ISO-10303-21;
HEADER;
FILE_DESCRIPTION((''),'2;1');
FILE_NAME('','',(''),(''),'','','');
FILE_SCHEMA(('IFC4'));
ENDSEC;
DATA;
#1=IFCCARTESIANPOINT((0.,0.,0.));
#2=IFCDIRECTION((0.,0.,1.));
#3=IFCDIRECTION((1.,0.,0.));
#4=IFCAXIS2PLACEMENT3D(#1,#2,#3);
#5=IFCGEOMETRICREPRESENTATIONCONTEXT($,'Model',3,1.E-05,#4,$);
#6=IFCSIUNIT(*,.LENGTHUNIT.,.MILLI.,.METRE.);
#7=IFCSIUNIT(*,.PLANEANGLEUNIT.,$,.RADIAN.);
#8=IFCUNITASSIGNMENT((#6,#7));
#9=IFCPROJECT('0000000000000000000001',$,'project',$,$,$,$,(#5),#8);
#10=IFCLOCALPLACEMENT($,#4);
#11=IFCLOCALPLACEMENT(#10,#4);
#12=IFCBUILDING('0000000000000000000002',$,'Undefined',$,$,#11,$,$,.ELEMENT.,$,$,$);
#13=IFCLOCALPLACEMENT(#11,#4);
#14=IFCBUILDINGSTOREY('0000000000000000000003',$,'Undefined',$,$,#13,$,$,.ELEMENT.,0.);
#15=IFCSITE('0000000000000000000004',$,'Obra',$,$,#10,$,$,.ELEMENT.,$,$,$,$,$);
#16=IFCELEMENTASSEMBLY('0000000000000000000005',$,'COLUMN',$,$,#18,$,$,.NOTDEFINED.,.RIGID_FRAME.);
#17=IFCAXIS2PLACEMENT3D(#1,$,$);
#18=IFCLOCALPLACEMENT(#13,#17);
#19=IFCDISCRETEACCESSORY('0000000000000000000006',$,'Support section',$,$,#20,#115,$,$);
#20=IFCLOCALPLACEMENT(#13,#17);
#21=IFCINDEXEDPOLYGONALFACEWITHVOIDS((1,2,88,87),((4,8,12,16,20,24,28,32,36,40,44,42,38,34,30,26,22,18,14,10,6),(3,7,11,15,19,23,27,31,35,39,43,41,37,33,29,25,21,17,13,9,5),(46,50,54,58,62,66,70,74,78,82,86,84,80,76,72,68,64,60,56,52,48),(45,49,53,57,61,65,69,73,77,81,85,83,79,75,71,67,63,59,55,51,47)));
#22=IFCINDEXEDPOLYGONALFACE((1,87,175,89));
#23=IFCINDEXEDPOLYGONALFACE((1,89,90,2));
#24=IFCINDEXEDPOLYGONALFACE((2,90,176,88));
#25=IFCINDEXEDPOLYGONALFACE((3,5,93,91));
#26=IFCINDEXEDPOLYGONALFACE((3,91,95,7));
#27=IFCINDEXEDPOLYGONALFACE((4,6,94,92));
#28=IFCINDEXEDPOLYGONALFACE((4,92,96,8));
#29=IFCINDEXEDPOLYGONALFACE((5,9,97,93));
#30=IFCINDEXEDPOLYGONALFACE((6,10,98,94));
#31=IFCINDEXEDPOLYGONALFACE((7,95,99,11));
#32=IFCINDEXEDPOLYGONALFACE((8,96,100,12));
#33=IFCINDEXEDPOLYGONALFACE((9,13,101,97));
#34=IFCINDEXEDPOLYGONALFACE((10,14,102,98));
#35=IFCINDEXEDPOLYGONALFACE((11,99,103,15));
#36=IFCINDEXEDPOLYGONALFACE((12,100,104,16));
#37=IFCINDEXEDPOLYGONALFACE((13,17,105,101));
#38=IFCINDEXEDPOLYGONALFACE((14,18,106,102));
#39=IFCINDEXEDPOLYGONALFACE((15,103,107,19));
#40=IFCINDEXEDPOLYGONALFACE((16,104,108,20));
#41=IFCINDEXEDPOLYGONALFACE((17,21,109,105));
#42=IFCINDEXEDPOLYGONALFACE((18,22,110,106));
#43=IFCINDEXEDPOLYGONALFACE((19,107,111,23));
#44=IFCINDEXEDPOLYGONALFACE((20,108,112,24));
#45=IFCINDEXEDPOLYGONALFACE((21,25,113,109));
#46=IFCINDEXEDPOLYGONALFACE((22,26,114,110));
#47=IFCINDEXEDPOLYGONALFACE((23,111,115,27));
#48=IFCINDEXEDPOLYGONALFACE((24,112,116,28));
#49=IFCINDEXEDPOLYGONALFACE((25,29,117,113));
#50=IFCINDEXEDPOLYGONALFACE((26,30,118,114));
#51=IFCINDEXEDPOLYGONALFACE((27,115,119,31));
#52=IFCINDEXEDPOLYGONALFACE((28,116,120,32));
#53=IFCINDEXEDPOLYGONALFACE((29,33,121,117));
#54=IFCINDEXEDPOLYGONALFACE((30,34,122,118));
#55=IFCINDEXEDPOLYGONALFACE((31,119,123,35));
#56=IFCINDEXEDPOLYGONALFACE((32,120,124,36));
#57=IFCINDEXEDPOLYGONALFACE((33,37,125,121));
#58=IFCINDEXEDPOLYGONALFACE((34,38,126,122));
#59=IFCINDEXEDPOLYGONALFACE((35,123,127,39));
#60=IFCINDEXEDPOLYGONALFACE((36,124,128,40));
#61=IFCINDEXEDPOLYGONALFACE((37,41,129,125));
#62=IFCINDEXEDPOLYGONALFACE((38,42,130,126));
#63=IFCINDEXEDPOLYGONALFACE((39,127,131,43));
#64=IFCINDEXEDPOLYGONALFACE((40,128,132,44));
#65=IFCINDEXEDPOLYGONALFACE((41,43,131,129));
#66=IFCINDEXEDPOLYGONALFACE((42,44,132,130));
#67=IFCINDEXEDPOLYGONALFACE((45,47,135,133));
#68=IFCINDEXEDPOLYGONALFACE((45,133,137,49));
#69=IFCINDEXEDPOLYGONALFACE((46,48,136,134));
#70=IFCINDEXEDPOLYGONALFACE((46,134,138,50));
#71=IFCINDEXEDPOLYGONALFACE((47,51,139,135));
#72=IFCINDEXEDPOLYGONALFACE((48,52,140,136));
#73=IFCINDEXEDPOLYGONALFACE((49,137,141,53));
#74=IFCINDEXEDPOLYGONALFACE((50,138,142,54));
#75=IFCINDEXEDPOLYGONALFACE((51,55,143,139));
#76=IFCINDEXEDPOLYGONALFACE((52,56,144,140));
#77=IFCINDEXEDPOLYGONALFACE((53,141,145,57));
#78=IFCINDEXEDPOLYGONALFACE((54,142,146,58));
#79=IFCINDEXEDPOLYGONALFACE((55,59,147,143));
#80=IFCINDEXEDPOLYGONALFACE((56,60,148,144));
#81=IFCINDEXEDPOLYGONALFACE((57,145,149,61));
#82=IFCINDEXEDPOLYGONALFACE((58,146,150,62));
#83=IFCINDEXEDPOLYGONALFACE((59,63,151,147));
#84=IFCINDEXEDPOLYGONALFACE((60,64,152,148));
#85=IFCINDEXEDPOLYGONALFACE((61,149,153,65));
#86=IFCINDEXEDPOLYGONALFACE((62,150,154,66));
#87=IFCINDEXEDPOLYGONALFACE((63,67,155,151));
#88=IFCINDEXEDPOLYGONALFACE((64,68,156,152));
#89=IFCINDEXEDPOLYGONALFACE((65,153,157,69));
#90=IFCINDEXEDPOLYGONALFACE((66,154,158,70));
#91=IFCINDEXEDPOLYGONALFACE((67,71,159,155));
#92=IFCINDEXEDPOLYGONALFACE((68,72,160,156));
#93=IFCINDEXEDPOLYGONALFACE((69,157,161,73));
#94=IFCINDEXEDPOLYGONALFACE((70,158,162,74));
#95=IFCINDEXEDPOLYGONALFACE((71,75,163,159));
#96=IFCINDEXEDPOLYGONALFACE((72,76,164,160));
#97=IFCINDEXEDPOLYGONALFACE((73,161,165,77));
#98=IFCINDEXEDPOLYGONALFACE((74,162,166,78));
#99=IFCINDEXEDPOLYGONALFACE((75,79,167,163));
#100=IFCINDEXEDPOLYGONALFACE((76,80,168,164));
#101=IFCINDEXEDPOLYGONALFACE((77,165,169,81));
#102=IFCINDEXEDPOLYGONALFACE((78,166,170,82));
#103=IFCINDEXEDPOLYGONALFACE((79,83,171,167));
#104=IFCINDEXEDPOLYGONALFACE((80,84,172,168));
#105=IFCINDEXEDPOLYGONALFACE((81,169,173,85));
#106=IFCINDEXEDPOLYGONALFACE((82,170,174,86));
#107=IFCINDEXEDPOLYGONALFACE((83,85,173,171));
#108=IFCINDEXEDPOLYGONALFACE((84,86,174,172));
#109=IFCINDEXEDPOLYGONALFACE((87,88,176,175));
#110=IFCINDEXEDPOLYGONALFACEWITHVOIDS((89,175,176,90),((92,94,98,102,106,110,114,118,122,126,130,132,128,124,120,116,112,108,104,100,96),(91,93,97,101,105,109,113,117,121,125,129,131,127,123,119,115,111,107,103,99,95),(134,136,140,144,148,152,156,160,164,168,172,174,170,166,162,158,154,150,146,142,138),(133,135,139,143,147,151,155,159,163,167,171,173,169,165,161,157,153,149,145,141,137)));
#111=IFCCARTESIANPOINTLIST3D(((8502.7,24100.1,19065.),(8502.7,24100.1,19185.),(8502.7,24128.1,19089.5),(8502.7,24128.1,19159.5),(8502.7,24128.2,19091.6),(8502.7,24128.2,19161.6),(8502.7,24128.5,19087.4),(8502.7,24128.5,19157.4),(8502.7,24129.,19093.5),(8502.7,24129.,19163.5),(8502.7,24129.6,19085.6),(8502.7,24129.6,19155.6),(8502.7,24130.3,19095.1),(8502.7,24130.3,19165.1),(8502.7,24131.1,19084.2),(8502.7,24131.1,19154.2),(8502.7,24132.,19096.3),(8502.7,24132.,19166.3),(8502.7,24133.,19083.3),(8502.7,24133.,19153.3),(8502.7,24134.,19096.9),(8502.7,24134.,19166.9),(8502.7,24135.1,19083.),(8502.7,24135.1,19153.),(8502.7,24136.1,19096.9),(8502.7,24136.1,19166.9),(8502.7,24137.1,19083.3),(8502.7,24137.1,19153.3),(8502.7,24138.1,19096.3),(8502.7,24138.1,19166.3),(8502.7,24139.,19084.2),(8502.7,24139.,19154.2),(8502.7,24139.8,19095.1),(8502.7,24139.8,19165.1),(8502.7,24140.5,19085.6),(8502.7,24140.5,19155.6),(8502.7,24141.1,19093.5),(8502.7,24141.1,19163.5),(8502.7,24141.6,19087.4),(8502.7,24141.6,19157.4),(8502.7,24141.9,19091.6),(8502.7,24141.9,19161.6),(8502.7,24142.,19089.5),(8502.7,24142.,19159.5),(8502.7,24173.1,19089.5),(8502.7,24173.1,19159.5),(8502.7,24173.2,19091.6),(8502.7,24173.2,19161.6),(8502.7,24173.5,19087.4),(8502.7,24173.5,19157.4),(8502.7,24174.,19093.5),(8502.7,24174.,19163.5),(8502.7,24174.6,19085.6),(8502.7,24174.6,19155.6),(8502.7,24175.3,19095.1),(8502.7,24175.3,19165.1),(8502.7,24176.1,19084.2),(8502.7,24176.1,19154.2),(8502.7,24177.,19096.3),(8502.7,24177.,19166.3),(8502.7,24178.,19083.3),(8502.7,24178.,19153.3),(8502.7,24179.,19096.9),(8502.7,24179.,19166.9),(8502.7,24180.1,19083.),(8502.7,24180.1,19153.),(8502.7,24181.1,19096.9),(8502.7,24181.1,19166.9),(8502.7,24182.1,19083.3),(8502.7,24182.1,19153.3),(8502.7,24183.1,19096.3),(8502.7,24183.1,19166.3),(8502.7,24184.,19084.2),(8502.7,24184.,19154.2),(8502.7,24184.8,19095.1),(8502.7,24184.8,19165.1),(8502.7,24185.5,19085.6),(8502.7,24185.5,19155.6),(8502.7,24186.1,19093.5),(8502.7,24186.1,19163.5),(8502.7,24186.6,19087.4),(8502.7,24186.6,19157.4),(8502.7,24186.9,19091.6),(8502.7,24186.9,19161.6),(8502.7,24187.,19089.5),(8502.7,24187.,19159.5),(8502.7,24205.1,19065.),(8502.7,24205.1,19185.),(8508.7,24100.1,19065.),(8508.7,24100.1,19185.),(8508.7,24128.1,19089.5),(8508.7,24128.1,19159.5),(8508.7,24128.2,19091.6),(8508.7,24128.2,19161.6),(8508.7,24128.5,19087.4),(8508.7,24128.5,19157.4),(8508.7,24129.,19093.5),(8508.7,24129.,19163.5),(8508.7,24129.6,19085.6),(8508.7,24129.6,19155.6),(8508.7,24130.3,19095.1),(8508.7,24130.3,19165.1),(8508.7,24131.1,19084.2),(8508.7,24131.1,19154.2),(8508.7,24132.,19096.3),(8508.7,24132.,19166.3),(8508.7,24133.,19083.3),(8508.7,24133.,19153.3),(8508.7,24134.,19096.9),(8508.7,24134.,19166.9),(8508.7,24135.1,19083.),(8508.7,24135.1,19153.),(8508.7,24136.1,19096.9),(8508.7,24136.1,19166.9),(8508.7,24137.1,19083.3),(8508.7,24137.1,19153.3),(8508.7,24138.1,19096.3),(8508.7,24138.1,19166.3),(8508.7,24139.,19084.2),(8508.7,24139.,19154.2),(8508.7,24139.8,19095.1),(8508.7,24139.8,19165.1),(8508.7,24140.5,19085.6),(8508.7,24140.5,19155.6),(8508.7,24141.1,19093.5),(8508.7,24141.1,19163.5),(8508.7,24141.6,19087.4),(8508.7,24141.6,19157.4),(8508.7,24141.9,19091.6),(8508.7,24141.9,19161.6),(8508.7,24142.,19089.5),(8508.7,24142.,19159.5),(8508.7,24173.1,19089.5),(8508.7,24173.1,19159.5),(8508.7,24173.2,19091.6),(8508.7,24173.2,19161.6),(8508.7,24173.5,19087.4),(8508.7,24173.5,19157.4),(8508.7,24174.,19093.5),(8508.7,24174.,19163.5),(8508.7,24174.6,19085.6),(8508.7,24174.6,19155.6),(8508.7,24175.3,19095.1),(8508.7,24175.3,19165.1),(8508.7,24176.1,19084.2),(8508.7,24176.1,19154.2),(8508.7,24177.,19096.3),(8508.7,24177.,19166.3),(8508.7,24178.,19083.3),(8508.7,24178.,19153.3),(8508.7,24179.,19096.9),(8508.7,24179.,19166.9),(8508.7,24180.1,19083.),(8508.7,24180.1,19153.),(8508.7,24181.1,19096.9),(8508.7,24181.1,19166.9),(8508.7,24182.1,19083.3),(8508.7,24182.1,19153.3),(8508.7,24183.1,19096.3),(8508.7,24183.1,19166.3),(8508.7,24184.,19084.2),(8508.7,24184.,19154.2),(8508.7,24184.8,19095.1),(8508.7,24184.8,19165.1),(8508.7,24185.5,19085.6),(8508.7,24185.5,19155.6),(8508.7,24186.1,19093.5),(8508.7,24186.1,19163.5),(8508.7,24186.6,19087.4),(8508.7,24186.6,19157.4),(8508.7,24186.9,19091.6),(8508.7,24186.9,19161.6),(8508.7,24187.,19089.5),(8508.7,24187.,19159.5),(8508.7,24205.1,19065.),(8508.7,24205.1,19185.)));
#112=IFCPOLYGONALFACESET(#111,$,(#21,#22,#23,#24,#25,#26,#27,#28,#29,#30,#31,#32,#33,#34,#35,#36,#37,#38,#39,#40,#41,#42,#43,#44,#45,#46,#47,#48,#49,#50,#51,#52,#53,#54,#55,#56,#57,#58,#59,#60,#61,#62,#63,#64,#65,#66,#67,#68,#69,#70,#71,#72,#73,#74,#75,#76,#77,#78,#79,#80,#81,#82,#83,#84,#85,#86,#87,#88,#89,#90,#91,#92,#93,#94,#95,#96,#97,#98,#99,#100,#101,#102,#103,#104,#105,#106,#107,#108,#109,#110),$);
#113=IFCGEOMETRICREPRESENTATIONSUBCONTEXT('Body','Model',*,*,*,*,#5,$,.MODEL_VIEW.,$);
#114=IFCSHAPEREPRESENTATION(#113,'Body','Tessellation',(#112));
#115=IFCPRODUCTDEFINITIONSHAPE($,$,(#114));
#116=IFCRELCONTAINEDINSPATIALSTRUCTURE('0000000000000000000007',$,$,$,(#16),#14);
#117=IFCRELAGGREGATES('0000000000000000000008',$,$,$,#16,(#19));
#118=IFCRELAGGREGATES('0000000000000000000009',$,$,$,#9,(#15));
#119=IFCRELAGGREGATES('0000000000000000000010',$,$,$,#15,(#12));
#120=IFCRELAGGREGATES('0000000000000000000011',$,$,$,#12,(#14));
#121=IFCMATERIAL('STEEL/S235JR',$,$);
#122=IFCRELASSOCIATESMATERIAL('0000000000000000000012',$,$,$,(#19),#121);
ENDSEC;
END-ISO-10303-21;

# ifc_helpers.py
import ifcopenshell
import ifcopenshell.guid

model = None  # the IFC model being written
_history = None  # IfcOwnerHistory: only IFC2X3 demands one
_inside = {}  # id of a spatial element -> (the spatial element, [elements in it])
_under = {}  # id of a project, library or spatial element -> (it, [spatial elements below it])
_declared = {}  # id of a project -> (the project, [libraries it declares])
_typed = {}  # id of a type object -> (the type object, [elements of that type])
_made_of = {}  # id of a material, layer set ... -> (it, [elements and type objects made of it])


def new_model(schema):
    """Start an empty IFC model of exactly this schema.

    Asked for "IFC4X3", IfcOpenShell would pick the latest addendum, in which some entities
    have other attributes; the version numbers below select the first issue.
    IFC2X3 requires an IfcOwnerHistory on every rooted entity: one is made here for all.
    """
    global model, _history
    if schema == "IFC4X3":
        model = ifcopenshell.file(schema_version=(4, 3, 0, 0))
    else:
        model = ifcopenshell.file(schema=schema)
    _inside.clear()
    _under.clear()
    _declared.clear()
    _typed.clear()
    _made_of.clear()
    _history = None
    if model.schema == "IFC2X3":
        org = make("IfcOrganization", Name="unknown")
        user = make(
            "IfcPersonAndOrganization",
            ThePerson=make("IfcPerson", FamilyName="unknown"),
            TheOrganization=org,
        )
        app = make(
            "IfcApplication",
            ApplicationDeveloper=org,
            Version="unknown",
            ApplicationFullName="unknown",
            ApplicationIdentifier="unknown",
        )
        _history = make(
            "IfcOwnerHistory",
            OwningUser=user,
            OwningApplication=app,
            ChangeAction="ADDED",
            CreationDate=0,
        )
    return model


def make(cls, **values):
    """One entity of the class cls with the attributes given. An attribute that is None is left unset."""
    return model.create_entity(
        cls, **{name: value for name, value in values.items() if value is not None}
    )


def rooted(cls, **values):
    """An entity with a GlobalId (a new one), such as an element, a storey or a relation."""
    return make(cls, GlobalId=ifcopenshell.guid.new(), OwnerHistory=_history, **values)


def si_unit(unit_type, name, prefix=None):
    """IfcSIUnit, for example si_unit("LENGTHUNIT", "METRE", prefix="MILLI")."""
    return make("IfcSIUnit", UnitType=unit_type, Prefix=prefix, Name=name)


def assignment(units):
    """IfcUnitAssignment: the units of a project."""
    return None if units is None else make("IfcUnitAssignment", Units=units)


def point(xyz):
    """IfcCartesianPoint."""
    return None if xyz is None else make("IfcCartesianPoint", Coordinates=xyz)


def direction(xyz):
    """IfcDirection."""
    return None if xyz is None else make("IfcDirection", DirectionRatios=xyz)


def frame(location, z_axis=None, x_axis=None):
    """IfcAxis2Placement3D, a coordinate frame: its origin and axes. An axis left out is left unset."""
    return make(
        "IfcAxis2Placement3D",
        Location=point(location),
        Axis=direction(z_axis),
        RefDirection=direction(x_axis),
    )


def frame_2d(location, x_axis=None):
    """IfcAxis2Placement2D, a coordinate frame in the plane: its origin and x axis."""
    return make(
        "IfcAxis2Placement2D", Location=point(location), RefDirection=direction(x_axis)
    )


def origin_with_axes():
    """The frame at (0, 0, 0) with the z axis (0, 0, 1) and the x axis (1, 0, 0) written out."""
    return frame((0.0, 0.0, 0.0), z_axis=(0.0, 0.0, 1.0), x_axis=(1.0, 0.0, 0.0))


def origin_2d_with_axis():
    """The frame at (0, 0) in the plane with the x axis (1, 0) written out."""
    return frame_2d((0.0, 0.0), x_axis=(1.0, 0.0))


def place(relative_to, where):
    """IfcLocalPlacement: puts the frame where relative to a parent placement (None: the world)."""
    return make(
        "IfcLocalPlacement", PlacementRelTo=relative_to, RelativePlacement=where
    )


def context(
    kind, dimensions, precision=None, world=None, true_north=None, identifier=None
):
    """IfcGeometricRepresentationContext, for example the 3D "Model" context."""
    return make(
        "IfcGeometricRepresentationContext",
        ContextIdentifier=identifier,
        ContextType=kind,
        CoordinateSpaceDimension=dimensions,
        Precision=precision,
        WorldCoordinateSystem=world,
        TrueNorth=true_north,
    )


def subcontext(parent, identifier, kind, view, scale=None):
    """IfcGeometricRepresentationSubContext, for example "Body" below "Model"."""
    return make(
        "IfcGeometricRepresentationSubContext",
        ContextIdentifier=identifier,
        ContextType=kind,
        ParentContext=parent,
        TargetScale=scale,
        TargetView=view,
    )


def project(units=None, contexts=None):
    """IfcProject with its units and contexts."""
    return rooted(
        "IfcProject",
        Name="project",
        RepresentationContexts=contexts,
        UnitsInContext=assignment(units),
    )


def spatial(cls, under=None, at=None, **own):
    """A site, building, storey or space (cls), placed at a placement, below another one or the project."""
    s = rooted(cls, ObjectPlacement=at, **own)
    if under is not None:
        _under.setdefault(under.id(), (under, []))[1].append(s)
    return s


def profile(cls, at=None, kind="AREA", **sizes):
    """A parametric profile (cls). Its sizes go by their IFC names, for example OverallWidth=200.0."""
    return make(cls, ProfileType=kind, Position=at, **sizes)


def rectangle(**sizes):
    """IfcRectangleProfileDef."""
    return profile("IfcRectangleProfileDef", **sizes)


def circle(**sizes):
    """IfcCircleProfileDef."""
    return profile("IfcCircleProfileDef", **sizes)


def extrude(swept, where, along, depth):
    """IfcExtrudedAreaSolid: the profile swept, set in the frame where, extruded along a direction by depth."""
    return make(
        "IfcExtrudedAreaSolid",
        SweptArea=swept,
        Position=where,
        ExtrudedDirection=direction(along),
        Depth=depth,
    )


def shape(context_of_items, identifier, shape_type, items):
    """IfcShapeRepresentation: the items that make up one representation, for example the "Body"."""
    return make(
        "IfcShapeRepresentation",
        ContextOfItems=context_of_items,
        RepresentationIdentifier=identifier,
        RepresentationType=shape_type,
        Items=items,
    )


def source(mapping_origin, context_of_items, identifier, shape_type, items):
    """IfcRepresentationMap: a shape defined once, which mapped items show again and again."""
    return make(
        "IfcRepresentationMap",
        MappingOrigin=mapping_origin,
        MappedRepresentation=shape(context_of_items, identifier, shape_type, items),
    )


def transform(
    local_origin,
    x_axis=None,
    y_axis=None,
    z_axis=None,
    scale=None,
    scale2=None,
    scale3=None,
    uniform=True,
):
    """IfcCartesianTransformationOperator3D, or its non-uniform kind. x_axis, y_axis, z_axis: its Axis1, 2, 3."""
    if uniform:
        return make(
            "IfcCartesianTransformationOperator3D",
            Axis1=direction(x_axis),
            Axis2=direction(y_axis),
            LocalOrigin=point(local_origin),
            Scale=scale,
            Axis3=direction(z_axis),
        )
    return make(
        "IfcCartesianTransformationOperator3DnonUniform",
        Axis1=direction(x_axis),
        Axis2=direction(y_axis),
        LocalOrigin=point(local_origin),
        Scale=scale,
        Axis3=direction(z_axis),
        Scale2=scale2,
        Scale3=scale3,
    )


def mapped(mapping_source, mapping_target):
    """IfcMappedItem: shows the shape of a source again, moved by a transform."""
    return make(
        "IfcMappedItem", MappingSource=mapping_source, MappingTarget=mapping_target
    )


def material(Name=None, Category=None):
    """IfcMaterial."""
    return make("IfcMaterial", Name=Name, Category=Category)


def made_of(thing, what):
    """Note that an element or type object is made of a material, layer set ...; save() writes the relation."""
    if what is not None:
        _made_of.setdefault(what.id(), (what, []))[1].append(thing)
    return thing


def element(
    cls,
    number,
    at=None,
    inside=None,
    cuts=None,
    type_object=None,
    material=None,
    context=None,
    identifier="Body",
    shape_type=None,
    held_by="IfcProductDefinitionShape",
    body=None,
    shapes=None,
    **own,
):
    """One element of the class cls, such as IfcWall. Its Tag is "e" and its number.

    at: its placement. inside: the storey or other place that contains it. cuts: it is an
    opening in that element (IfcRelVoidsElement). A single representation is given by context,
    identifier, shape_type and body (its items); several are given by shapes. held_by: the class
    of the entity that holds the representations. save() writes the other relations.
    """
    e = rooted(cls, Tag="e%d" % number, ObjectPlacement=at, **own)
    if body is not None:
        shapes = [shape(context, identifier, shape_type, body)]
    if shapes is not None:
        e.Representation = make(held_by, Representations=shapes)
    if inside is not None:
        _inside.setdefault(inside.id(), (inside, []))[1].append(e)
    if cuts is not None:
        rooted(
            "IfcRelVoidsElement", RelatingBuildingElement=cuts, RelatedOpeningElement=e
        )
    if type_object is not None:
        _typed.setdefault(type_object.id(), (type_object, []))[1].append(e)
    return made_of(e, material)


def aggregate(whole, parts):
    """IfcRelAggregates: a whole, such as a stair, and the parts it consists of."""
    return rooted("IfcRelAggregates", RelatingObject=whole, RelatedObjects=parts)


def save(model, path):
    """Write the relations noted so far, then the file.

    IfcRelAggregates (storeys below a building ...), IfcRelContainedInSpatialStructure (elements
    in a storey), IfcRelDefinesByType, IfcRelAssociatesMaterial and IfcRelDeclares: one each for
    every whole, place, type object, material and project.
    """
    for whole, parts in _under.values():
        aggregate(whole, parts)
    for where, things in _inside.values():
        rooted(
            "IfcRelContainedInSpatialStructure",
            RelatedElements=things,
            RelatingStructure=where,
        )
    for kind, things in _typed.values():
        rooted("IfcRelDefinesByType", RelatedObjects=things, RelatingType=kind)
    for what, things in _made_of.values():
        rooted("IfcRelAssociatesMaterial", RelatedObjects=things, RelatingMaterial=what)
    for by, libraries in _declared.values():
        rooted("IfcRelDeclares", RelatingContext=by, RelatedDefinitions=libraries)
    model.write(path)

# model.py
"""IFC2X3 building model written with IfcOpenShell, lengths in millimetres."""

from ifc_helpers import new_model, si_unit, frame, origin_with_axes, origin_2d_with_axis, place, context, subcontext, project, spatial, rectangle, circle, extrude, source, transform, mapped, material, element, aggregate, save


model = new_model("IFC2X3")

# Units and contexts
model_context = context("Model", 3, precision=1e-05, world=origin_with_axes())
body_context = subcontext(model_context, "Body", "Model", "MODEL_VIEW")
ifc_project = project(units=[si_unit("LENGTHUNIT", "METRE", prefix="MILLI"), si_unit("PLANEANGLEUNIT", "RADIAN")], contexts=[model_context])

# Site, building, storey
site_placement = place(None, origin_with_axes())
site = spatial("IfcSite", under=ifc_project, at=site_placement, Name="Obra", CompositionType="ELEMENT")
building_placement = place(site_placement, origin_with_axes())
building = spatial("IfcBuilding", under=site, at=building_placement, Name="Undefined", CompositionType="ELEMENT")
storey_placement = place(building_placement, origin_with_axes())
storey = spatial("IfcBuildingStorey", under=building, at=storey_placement, Name="Undefined", CompositionType="ELEMENT", Elevation=0.0)

# Element assembly
assembly_1_placement = place(storey_placement, origin_with_axes())
assembly_1 = element("IfcElementAssembly", 1, at=assembly_1_placement, inside=storey, Name="COLUMN", AssemblyPlace="NOTDEFINED", PredefinedType="RIGID_FRAME")
ifc_material_1 = material(Name="STEEL/S235JR")

# Discrete accessory, opening
discrete_accessory_1_placement = place(assembly_1_placement, frame((8505.7, 24152.6, 19065.0), z_axis=(0.0, 0.0, 1.0), x_axis=(0.0, -1.0, 0.0)))
discrete_accessory_1 = element("IfcDiscreteAccessory", 2, at=discrete_accessory_1_placement, material=ifc_material_1, Name="Support section", context=body_context, shape_type="SweptSolid", body=[
    extrude(rectangle(XDim=6.0, YDim=105.0, at=origin_2d_with_axis()), frame((0.0, 0.0, 120.0), z_axis=(0.0, 0.0, -1.0), x_axis=(0.0, 1.0, 0.0)), (0.0, 0.0, 1.0), 120.0),
])
shared_shape_1 = source(origin_with_axes(), body_context, "Body", "SweptSolid", [
    extrude(circle(Radius=7.0, at=origin_2d_with_axis()), frame((0.0, -8.6, 0.0), z_axis=(0.0, 1.0, 0.0), x_axis=(1.0, 0.0, 0.0)), (0.0, 0.0, 1.0), 6.2),
])
opening_1_placement = place(assembly_1_placement, frame((8500.2, 24110.1, 19205.0), z_axis=(0.0, 1.0, 0.0), x_axis=(0.0, 0.0, -1.0)))
element("IfcOpeningElement", 3, at=opening_1_placement, cuts=discrete_accessory_1, ObjectType="Opening", context=body_context, shape_type="MappedRepresentation", body=[
    mapped(shared_shape_1, transform((45.0, 0.0, 25.0))),
    mapped(shared_shape_1, transform((45.0, 0.0, 70.0))),
    mapped(shared_shape_1, transform((115.0, 0.0, 25.0))),
    mapped(shared_shape_1, transform((115.0, 0.0, 70.0))),
])
aggregate(assembly_1, [discrete_accessory_1])

save(model, "model.ifc")
